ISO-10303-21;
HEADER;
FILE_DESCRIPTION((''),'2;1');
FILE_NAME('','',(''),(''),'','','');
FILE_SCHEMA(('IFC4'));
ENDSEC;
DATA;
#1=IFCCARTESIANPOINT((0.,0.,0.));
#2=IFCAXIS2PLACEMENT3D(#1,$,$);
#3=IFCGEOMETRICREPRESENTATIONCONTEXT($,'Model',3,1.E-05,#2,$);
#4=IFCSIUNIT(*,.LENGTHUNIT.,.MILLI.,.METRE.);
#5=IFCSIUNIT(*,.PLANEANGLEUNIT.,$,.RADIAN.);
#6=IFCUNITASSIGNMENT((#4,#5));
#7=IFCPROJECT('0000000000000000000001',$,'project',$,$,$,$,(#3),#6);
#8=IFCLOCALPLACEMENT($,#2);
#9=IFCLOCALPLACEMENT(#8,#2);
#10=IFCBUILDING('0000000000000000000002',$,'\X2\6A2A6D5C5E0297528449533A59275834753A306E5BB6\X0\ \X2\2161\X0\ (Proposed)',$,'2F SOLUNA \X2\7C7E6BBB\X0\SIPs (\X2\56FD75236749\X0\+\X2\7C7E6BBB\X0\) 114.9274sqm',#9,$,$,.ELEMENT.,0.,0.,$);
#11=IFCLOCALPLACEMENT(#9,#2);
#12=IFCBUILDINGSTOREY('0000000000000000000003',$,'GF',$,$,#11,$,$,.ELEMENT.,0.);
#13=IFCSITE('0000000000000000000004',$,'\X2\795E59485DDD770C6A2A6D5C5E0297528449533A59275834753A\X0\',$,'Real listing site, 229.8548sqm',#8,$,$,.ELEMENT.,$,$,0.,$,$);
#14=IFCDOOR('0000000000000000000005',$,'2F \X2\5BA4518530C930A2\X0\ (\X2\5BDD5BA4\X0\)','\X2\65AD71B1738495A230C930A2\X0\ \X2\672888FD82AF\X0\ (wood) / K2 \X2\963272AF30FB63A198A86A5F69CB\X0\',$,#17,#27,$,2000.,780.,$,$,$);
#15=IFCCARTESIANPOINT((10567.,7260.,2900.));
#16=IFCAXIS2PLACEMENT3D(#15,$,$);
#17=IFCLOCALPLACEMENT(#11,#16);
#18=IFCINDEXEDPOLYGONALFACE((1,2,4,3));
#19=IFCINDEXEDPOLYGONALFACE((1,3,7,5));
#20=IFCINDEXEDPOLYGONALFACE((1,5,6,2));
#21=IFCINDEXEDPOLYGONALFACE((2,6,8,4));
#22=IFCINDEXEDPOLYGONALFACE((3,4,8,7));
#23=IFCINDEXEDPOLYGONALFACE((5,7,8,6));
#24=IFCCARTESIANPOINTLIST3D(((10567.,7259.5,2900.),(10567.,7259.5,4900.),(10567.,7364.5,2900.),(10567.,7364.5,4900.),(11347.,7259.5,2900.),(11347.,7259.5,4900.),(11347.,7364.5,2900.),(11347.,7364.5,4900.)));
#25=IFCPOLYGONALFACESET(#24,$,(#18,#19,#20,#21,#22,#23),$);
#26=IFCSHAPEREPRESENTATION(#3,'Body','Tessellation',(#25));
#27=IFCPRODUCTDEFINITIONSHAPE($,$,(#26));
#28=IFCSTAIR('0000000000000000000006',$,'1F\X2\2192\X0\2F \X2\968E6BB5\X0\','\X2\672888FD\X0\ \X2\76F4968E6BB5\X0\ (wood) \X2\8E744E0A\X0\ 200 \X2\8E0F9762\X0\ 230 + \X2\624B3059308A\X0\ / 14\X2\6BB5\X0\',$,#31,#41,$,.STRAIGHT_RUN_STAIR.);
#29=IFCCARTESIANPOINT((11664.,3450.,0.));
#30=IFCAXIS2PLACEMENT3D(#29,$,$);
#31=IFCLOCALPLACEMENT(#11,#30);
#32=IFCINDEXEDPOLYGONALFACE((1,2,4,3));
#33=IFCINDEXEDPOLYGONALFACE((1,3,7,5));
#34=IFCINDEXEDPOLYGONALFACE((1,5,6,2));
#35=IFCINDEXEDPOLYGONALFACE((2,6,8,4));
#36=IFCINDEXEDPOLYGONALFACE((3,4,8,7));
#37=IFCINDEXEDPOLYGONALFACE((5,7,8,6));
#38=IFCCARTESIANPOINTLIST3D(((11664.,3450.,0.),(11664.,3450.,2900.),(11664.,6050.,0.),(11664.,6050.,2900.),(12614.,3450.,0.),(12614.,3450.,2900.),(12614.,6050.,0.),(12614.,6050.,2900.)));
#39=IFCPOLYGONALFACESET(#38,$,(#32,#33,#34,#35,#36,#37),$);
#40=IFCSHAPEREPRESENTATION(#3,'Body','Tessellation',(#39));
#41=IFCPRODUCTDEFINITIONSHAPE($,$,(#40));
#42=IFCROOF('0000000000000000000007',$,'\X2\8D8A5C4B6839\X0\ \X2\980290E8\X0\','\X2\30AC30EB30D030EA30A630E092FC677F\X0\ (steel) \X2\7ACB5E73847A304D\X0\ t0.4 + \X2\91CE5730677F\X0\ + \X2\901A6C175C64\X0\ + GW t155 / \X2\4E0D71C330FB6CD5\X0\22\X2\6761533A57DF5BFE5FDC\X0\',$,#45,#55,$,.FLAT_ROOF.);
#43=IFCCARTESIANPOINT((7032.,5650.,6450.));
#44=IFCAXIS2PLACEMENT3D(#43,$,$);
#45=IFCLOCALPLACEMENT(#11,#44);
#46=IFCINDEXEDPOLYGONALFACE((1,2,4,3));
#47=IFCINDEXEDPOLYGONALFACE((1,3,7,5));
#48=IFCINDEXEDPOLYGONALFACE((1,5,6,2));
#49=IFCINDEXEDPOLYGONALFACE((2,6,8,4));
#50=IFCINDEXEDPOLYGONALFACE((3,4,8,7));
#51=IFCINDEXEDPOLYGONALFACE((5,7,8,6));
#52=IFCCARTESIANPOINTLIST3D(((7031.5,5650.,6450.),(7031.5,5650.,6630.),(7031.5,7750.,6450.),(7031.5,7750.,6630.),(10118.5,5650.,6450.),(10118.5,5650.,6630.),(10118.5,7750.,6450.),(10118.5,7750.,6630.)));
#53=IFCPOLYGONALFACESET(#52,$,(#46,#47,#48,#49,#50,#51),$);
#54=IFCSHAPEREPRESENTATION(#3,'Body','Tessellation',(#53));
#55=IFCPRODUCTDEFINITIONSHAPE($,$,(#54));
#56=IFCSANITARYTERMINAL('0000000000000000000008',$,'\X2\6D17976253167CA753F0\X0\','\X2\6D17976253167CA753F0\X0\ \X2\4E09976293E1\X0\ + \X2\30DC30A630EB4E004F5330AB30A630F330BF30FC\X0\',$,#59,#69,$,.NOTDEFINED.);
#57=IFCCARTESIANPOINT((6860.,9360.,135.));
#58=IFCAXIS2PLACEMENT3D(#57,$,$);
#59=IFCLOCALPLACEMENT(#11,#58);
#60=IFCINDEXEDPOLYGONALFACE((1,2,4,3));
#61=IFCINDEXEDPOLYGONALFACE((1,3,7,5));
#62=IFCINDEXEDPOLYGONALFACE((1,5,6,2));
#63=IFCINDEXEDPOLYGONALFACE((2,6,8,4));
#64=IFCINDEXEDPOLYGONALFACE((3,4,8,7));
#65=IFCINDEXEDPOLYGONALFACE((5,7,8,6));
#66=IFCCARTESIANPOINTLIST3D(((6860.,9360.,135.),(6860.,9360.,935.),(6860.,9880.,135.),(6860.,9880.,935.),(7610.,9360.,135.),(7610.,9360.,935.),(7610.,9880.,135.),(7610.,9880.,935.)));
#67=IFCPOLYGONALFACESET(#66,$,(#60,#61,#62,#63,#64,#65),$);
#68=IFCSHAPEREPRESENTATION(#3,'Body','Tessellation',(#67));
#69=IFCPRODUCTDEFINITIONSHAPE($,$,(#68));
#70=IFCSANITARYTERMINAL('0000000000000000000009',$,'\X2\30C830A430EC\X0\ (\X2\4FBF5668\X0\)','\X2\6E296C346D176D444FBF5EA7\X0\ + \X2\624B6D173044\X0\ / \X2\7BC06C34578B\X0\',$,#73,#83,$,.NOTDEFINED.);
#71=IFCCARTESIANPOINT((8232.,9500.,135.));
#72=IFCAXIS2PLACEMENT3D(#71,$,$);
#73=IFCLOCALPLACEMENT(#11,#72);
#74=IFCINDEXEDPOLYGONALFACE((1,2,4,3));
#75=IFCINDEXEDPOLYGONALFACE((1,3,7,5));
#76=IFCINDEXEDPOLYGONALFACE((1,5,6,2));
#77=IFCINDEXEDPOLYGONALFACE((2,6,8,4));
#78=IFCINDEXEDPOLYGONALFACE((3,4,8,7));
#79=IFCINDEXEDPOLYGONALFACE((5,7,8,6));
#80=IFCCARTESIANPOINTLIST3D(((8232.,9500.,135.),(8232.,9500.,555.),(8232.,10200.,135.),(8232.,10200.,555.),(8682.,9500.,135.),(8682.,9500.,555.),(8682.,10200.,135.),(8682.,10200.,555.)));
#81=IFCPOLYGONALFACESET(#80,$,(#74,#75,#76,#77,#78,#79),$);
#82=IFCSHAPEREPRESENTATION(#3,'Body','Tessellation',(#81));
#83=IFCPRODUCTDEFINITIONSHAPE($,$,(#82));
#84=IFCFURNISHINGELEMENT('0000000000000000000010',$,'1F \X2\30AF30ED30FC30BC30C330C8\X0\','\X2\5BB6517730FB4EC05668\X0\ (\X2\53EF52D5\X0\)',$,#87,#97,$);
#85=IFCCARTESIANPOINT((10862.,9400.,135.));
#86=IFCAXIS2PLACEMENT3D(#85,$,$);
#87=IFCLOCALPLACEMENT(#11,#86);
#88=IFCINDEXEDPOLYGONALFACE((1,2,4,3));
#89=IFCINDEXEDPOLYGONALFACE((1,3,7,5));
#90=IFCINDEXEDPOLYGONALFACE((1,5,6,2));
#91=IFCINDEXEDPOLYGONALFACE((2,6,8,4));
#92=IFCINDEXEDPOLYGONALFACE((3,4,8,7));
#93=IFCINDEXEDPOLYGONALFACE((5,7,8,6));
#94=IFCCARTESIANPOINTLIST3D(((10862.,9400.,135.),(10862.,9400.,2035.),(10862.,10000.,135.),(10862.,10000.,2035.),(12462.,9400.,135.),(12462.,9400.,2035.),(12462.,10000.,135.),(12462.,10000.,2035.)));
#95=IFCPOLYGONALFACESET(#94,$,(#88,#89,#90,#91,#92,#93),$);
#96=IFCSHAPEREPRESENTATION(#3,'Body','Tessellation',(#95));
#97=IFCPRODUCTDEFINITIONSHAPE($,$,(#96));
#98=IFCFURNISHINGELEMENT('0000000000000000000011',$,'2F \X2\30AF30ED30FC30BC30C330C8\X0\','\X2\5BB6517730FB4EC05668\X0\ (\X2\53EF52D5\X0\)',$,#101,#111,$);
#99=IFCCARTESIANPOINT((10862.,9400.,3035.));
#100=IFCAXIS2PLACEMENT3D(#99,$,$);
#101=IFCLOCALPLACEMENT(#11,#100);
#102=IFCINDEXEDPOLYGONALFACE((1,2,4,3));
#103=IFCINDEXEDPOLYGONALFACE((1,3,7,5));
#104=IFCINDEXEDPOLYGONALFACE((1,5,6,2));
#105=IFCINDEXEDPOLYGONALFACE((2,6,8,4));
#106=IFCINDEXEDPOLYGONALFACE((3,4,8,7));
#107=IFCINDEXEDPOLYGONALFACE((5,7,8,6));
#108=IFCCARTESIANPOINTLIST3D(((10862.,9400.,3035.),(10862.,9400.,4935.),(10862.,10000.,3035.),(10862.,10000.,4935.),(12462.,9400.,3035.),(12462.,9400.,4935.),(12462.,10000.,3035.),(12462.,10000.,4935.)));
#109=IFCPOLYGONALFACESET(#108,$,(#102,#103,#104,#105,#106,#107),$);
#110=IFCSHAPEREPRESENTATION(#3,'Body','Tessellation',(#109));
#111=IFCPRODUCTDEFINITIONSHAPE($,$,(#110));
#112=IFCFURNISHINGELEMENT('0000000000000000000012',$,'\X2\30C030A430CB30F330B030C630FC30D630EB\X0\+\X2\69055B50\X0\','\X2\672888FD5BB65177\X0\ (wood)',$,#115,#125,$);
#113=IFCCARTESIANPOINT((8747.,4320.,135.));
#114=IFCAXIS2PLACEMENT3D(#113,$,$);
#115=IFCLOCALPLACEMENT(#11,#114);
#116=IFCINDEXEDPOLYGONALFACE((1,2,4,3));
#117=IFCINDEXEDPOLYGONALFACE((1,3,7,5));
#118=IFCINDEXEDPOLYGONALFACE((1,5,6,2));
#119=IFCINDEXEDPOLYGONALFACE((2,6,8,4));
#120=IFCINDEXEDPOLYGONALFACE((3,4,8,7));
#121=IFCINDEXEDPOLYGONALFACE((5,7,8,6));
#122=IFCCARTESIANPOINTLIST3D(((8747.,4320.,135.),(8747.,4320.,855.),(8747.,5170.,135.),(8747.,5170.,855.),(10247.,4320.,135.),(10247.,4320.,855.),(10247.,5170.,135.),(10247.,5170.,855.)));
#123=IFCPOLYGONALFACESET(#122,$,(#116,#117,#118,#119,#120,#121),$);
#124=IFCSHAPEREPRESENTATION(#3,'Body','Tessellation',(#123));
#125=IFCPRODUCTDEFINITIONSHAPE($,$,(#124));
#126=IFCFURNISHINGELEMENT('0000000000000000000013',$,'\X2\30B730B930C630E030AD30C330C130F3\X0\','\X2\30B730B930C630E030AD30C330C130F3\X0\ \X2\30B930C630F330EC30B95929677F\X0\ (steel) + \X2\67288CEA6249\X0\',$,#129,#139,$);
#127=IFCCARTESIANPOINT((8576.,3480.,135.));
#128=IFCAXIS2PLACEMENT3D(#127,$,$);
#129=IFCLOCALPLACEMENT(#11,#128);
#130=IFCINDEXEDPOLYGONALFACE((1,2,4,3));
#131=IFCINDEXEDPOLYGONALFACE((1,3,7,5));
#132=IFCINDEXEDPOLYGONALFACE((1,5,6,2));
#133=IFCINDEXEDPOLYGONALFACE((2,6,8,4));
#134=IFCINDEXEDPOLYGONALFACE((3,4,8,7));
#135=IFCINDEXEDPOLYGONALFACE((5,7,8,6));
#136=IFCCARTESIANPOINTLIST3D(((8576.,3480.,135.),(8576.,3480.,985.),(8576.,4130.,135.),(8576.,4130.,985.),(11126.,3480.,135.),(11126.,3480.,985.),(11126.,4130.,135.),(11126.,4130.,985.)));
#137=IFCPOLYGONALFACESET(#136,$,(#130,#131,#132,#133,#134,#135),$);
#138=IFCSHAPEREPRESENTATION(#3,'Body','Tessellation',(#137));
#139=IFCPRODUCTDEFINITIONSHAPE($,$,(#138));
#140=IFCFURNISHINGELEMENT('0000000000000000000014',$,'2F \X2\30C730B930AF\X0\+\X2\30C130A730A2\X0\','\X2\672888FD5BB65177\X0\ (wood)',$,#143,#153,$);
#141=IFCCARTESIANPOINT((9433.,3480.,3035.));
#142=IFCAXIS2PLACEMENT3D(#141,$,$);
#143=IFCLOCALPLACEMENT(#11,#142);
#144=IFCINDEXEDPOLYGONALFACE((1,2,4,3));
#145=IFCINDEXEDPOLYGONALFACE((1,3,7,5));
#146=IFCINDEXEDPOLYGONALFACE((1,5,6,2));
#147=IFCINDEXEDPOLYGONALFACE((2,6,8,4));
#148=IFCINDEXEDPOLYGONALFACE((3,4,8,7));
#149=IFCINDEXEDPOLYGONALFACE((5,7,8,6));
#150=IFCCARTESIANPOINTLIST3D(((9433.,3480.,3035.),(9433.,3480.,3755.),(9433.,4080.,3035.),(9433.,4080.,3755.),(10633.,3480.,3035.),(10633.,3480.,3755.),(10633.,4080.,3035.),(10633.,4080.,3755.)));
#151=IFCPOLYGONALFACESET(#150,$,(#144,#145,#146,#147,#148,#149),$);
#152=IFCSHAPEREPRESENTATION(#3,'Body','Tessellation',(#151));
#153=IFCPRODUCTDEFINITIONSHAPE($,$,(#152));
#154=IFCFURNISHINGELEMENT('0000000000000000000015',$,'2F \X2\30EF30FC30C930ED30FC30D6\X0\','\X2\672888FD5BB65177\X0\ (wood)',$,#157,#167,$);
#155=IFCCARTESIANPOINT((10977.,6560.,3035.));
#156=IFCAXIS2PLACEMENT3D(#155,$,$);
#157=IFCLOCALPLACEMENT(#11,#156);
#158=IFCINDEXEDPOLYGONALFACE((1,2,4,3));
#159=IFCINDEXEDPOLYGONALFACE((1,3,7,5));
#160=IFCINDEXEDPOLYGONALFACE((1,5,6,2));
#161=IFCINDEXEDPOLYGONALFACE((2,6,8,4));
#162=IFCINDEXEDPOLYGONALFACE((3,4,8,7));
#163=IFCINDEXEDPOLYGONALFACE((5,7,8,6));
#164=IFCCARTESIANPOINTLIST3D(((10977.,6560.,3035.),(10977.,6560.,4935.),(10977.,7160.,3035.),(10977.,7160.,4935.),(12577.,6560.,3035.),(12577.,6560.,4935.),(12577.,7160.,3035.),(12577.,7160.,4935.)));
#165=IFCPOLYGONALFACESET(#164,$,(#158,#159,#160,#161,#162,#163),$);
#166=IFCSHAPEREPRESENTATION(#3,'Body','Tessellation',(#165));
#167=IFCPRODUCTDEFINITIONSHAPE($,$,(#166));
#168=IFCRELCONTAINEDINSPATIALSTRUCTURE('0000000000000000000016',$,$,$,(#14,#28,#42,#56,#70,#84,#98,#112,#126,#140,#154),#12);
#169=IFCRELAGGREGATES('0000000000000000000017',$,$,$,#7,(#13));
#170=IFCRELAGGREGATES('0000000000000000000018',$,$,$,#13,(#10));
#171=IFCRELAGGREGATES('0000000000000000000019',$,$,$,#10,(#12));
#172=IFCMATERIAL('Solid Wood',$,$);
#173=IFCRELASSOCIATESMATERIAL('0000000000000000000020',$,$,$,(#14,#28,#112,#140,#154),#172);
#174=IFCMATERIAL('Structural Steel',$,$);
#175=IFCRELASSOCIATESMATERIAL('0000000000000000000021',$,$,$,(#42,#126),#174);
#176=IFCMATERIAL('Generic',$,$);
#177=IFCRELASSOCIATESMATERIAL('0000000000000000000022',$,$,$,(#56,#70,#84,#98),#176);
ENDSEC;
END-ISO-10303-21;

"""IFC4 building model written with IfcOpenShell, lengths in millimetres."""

from ifc_helpers import new_model, si_unit, frame, frame_2d, origin, place, context, project, spatial, rectangle, extrude, material, element, save


model = new_model("IFC4")

# Units and contexts
model_context = context("Model", 3, precision=1e-05, world=origin())
ifc_project = project(units=[si_unit("LENGTHUNIT", "METRE", prefix="MILLI"), si_unit("PLANEANGLEUNIT", "RADIAN")], contexts=[model_context])

# Site, building, storey
site_placement = place(None, origin())
site = spatial("IfcSite", under=ifc_project, at=site_placement, Name="神奈川県横浜市青葉区大場町", ObjectType="Real listing site, 229.8548sqm", CompositionType="ELEMENT", RefElevation=0.0)
building_placement = place(site_placement, origin())
building = spatial("IfcBuilding", under=site, at=building_placement, Name="横浜市青葉区大場町の家 Ⅱ (Proposed)", ObjectType="2F SOLUNA 籾殻SIPs (国産杉+籾殻) 114.9274sqm", CompositionType="ELEMENT", ElevationOfRefHeight=0.0, ElevationOfTerrain=0.0)
storey_placement = place(building_placement, origin())
storey = spatial("IfcBuildingStorey", under=building, at=storey_placement, Name="GF", CompositionType="ELEMENT", Elevation=0.0)

# Shared definitions
ifc_material_1 = material(Name="Solid Wood")

# Door
door_1_placement = place(storey_placement, frame((10567.0, 7260.0, 2900.0)))
element("IfcDoor", 1, at=door_1_placement, inside=storey, material=ifc_material_1, Name="2F 室内ドア (寝室)", Description="断熱玄関ドア 木製芯 (wood) / K2 防犯・採風機構", OverallHeight=2000.0, OverallWidth=780.0, context=model_context, shape_type="SweptSolid", body=[
    extrude(rectangle(XDim=780.0, YDim=105.0, at=frame_2d((390.0, 52.0))), frame((10567.0, 7260.0, 2900.0)), (0.0, 0.0, 1.0), 2000.0),
])

# Stair
stair_placement = place(storey_placement, frame((11664.0, 3450.0, 0.0)))
element("IfcStair", 2, at=stair_placement, inside=storey, material=ifc_material_1, Name="1F→2F 階段", Description="木製 直階段 (wood) 蹴上 200 踏面 230 + 手すり / 14段", PredefinedType="STRAIGHT_RUN_STAIR", context=model_context, shape_type="SweptSolid", body=[
    extrude(rectangle(XDim=950.0, YDim=2600.0, at=frame_2d((475.0, 1300.0))), frame((11664.0, 3450.0, 0.0)), (0.0, 0.0, 1.0), 2900.0),
])

# Roof
ifc_material_2 = material(Name="Structural Steel")
roof_placement = place(storey_placement, frame((7032.0, 5650.0, 6450.0)))
element("IfcRoof", 3, at=roof_placement, inside=storey, material=ifc_material_2, Name="越屋根 頂部", Description="ガルバリウム鋼板 (steel) 立平葺き t0.4 + 野地板 + 通気層 + GW t155 / 不燃・法22条区域対応", PredefinedType="FLAT_ROOF", context=model_context, shape_type="SweptSolid", body=[
    extrude(rectangle(XDim=3087.0, YDim=2100.0, at=frame_2d((1543.0, 1050.0))), frame((7032.0, 5650.0, 6450.0)), (0.0, 0.0, 1.0), 180.0),
])

# Sanitary terminals
ifc_material_3 = material(Name="Generic")
sanitary_terminal_1_placement = place(storey_placement, frame((6860.0, 9360.0, 135.0)))
element("IfcSanitaryTerminal", 4, at=sanitary_terminal_1_placement, inside=storey, material=ifc_material_3, Name="洗面化粧台", Description="洗面化粧台 三面鏡 + ボウル一体カウンター", PredefinedType="NOTDEFINED", context=model_context, shape_type="SweptSolid", body=[
    extrude(rectangle(XDim=750.0, YDim=520.0, at=frame_2d((375.0, 260.0))), frame((6860.0, 9360.0, 135.0)), (0.0, 0.0, 1.0), 800.0),
])
sanitary_terminal_2_placement = place(storey_placement, frame((8232.0, 9500.0, 135.0)))
element("IfcSanitaryTerminal", 5, at=sanitary_terminal_2_placement, inside=storey, material=ifc_material_3, Name="トイレ (便器)", Description="温水洗浄便座 + 手洗い / 節水型", PredefinedType="NOTDEFINED", context=model_context, shape_type="SweptSolid", body=[
    extrude(rectangle(XDim=450.0, YDim=700.0, at=frame_2d((225.0, 350.0))), frame((8232.0, 9500.0, 135.0)), (0.0, 0.0, 1.0), 420.0),
])

# Furnishing elements
furnishing_1_placement = place(storey_placement, frame((10862.0, 9400.0, 135.0)))
element("IfcFurnishingElement", 6, at=furnishing_1_placement, inside=storey, material=ifc_material_3, Name="1F クローゼット", Description="家具・什器 (可動)", context=model_context, shape_type="SweptSolid", body=[
    extrude(rectangle(XDim=1600.0, YDim=600.0, at=frame_2d((800.0, 300.0))), frame((10862.0, 9400.0, 135.0)), (0.0, 0.0, 1.0), 1900.0),
])
furnishing_2_placement = place(storey_placement, frame((10862.0, 9400.0, 3035.0)))
element("IfcFurnishingElement", 7, at=furnishing_2_placement, inside=storey, material=ifc_material_3, Name="2F クローゼット", Description="家具・什器 (可動)", context=model_context, shape_type="SweptSolid", body=[
    extrude(rectangle(XDim=1600.0, YDim=600.0, at=frame_2d((800.0, 300.0))), frame((10862.0, 9400.0, 3035.0)), (0.0, 0.0, 1.0), 1900.0),
])
furnishing_3_placement = place(storey_placement, frame((8747.0, 4320.0, 135.0)))
element("IfcFurnishingElement", 8, at=furnishing_3_placement, inside=storey, material=ifc_material_1, Name="ダイニングテーブル+椅子", Description="木製家具 (wood)", context=model_context, shape_type="SweptSolid", body=[
    extrude(rectangle(XDim=1500.0, YDim=850.0, at=frame_2d((750.0, 425.0))), frame((8747.0, 4320.0, 135.0)), (0.0, 0.0, 1.0), 720.0),
])
furnishing_4_placement = place(storey_placement, frame((8576.0, 3480.0, 135.0)))
element("IfcFurnishingElement", 9, at=furnishing_4_placement, inside=storey, material=ifc_material_2, Name="システムキッチン", Description="システムキッチン ステンレス天板 (steel) + 木質扉", context=model_context, shape_type="SweptSolid", body=[
    extrude(rectangle(XDim=2550.0, YDim=650.0, at=frame_2d((1275.0, 325.0))), frame((8576.0, 3480.0, 135.0)), (0.0, 0.0, 1.0), 850.0),
])
furnishing_5_placement = place(storey_placement, frame((9433.0, 3480.0, 3035.0)))
element("IfcFurnishingElement", 10, at=furnishing_5_placement, inside=storey, material=ifc_material_1, Name="2F デスク+チェア", Description="木製家具 (wood)", context=model_context, shape_type="SweptSolid", body=[
    extrude(rectangle(XDim=1200.0, YDim=600.0, at=frame_2d((600.0, 300.0))), frame((9433.0, 3480.0, 3035.0)), (0.0, 0.0, 1.0), 720.0),
])
furnishing_6_placement = place(storey_placement, frame((10977.0, 6560.0, 3035.0)))
element("IfcFurnishingElement", 11, at=furnishing_6_placement, inside=storey, material=ifc_material_1, Name="2F ワードローブ", Description="木製家具 (wood)", context=model_context, shape_type="SweptSolid", body=[
    extrude(rectangle(XDim=1600.0, YDim=600.0, at=frame_2d((800.0, 300.0))), frame((10977.0, 6560.0, 3035.0)), (0.0, 0.0, 1.0), 1900.0),
])

save(model, "model.ifc")
